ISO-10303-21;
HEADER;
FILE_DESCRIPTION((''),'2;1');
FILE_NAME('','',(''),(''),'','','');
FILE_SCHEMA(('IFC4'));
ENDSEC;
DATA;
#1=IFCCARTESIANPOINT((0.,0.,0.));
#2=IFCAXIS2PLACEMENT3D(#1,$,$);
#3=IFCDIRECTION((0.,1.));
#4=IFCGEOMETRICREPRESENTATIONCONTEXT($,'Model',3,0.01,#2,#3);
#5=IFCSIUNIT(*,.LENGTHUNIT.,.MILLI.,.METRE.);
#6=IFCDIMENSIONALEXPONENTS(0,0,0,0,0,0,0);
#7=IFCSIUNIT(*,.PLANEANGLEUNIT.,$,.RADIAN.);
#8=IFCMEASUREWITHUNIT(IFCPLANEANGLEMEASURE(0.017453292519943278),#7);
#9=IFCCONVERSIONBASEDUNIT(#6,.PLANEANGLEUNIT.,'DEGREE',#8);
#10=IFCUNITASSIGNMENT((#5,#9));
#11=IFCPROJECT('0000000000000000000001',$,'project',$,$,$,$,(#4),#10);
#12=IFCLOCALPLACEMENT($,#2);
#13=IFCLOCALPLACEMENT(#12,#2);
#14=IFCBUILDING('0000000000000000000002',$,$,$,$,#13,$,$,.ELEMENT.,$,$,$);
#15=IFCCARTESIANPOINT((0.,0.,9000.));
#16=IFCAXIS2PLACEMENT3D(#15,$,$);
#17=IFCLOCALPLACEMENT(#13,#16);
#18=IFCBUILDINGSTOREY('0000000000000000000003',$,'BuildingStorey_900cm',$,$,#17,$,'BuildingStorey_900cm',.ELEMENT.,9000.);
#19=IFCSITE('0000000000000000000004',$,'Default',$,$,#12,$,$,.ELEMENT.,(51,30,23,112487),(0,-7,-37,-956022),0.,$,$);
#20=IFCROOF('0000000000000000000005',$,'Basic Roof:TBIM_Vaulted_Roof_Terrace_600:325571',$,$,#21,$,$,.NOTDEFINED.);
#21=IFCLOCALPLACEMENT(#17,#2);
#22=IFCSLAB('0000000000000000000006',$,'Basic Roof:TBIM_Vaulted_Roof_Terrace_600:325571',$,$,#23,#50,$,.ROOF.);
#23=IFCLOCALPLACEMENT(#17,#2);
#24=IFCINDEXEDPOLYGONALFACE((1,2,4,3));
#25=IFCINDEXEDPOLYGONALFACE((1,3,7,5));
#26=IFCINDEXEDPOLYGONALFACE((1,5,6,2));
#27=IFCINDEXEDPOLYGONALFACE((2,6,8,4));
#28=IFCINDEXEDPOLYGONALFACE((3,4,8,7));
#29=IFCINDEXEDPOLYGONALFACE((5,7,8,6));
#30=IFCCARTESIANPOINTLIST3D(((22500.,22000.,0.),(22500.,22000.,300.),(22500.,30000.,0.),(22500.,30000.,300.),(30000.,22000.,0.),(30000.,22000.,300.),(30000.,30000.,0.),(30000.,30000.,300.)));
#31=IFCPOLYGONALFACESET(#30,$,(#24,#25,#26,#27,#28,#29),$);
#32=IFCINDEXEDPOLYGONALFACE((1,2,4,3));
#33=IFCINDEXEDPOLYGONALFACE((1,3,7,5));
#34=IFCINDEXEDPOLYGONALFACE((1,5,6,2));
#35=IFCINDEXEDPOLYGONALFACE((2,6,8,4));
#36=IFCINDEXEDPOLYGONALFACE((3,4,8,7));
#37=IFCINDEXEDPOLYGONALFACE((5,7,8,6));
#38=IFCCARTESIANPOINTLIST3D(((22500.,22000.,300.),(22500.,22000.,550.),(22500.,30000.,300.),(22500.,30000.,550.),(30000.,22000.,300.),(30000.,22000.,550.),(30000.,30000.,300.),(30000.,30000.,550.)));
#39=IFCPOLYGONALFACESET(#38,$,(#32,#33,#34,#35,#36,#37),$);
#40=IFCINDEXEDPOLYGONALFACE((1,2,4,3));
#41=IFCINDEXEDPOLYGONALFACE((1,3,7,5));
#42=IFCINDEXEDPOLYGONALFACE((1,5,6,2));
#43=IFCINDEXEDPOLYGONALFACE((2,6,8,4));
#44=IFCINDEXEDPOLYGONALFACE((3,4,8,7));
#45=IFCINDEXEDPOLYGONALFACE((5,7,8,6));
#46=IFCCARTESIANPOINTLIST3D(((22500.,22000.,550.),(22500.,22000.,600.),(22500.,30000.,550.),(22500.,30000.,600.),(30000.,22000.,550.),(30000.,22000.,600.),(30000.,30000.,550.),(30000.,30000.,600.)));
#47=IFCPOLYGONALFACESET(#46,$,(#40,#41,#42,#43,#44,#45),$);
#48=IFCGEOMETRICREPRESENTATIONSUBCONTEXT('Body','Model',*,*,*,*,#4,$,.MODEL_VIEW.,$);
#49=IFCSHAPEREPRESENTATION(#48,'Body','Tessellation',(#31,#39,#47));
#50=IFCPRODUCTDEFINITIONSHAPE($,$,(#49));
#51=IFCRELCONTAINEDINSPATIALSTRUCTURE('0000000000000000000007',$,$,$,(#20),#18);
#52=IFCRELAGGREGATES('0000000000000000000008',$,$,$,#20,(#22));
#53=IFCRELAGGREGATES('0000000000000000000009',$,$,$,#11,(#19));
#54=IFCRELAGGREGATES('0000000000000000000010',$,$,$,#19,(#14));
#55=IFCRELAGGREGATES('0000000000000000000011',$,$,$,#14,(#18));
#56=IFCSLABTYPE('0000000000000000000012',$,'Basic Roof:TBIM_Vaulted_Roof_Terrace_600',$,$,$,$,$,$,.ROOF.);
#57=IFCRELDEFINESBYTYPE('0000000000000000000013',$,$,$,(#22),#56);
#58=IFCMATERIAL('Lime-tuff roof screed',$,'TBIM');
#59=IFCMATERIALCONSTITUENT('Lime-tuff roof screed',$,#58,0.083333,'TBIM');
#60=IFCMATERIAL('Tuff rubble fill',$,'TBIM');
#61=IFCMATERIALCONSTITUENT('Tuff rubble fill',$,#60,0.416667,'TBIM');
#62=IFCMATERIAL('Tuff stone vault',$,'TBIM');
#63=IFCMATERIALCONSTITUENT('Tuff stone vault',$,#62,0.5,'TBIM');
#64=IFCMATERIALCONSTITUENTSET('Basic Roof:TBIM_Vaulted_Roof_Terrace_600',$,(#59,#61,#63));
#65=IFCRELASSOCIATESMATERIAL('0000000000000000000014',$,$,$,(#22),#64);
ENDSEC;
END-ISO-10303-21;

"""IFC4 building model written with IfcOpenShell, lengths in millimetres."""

from ifc_helpers import new_model, entity, si_unit, converted_unit, direction, frame, origin, place, context, subcontext, project, spatial, indexed_curve, outline, extrude, material, constituent, constituent_set, type_object, element, aggregate, save


model = new_model("IFC4")

# Units and contexts
model_context = context("Model", 3, precision=0.01, world=origin(), true_north=direction((0.0, 1.0)))
body_context = subcontext(model_context, "Body", "Model", "MODEL_VIEW")
ifc_project = project(units=[si_unit("LENGTHUNIT", "METRE", prefix="MILLI"), converted_unit("PLANEANGLEUNIT", "DEGREE", entity("IfcPlaneAngleMeasure", 0.017453292519943278), si_unit("PLANEANGLEUNIT", "RADIAN"), dimensions=[0, 0, 0, 0, 0, 0, 0])], contexts=[model_context])

# Site, building, storey
site_placement = place(None, origin())
site = spatial("IfcSite", under=ifc_project, at=site_placement, Name="Default", CompositionType="ELEMENT", RefLatitude=(51, 30, 23, 112487), RefLongitude=(0, -7, -37, -956022), RefElevation=0.0)
building_placement = place(site_placement, origin())
building = spatial("IfcBuilding", under=site, at=building_placement, CompositionType="ELEMENT")
storey_placement = place(building_placement, frame((0.0, 0.0, 9000.0)))
storey = spatial("IfcBuildingStorey", under=building, at=storey_placement, Name="BuildingStorey_900cm", LongName="BuildingStorey_900cm", CompositionType="ELEMENT", Elevation=9000.0)

# Shared definitions
ifc_material_1 = material(Name="Tuff rubble fill", Category="TBIM")
ifc_material_2 = material(Name="Tuff stone vault", Category="TBIM")

# Roof, slab
ifc_material_3 = material(Name="Lime-tuff roof screed", Category="TBIM")
ifc_constituent_1 = constituent(ifc_material_3, Name="Lime-tuff roof screed", Category="TBIM", fraction=0.083333)
ifc_constituent_2 = constituent(ifc_material_1, Name="Tuff rubble fill", Category="TBIM", fraction=0.416667)
ifc_constituent_3 = constituent(ifc_material_2, Name="Tuff stone vault", Category="TBIM", fraction=0.5)
ifc_constituent_set_1 = constituent_set(constituents=[ifc_constituent_1, ifc_constituent_2, ifc_constituent_3], Name="Basic Roof:TBIM_Vaulted_Roof_Terrace_600")
slab_type_1 = type_object("IfcSlabType", Name="Basic Roof:TBIM_Vaulted_Roof_Terrace_600", PredefinedType="ROOF")
roof_1_placement = place(storey_placement, frame((22500.0, 22000.0, 0.0)))
roof_1 = element("IfcRoof", 1, at=roof_1_placement, inside=storey, Name="Basic Roof:TBIM_Vaulted_Roof_Terrace_600:325571", PredefinedType="NOTDEFINED")
slab_1_placement = place(roof_1_placement, origin())
slab_1 = element("IfcSlab", 2, at=slab_1_placement, type_object=slab_type_1, material=ifc_constituent_set_1, Name="Basic Roof:TBIM_Vaulted_Roof_Terrace_600:325571", PredefinedType="ROOF", context=body_context, shape_type="SweptSolid", body=[
    extrude(outline(indexed_curve([(-3750.0, 4000.0), (-3750.0, -4000.0), (3750.0, -4000.0), (3750.0, 4000.0), (-3750.0, 4000.0)], self_intersect=False)), frame((3750.0, 4000.0, 0.0)), (0.0, 0.0, 1.0), 300.0),
    extrude(outline(indexed_curve([(-3750.0, 4000.0), (-3750.0, -4000.0), (3750.0, -4000.0), (3750.0, 4000.0), (-3750.0, 4000.0)], self_intersect=False)), frame((3750.0, 4000.0, 300.0)), (0.0, 0.0, 1.0), 250.0),
    extrude(outline(indexed_curve([(-3750.0, 4000.0), (-3750.0, -4000.0), (3750.0, -4000.0), (3750.0, 4000.0), (-3750.0, 4000.0)], self_intersect=False)), frame((3750.0, 4000.0, 550.0)), (0.0, 0.0, 1.0), 50.0),
])
aggregate(roof_1, [slab_1])

save(model, "model.ifc")
